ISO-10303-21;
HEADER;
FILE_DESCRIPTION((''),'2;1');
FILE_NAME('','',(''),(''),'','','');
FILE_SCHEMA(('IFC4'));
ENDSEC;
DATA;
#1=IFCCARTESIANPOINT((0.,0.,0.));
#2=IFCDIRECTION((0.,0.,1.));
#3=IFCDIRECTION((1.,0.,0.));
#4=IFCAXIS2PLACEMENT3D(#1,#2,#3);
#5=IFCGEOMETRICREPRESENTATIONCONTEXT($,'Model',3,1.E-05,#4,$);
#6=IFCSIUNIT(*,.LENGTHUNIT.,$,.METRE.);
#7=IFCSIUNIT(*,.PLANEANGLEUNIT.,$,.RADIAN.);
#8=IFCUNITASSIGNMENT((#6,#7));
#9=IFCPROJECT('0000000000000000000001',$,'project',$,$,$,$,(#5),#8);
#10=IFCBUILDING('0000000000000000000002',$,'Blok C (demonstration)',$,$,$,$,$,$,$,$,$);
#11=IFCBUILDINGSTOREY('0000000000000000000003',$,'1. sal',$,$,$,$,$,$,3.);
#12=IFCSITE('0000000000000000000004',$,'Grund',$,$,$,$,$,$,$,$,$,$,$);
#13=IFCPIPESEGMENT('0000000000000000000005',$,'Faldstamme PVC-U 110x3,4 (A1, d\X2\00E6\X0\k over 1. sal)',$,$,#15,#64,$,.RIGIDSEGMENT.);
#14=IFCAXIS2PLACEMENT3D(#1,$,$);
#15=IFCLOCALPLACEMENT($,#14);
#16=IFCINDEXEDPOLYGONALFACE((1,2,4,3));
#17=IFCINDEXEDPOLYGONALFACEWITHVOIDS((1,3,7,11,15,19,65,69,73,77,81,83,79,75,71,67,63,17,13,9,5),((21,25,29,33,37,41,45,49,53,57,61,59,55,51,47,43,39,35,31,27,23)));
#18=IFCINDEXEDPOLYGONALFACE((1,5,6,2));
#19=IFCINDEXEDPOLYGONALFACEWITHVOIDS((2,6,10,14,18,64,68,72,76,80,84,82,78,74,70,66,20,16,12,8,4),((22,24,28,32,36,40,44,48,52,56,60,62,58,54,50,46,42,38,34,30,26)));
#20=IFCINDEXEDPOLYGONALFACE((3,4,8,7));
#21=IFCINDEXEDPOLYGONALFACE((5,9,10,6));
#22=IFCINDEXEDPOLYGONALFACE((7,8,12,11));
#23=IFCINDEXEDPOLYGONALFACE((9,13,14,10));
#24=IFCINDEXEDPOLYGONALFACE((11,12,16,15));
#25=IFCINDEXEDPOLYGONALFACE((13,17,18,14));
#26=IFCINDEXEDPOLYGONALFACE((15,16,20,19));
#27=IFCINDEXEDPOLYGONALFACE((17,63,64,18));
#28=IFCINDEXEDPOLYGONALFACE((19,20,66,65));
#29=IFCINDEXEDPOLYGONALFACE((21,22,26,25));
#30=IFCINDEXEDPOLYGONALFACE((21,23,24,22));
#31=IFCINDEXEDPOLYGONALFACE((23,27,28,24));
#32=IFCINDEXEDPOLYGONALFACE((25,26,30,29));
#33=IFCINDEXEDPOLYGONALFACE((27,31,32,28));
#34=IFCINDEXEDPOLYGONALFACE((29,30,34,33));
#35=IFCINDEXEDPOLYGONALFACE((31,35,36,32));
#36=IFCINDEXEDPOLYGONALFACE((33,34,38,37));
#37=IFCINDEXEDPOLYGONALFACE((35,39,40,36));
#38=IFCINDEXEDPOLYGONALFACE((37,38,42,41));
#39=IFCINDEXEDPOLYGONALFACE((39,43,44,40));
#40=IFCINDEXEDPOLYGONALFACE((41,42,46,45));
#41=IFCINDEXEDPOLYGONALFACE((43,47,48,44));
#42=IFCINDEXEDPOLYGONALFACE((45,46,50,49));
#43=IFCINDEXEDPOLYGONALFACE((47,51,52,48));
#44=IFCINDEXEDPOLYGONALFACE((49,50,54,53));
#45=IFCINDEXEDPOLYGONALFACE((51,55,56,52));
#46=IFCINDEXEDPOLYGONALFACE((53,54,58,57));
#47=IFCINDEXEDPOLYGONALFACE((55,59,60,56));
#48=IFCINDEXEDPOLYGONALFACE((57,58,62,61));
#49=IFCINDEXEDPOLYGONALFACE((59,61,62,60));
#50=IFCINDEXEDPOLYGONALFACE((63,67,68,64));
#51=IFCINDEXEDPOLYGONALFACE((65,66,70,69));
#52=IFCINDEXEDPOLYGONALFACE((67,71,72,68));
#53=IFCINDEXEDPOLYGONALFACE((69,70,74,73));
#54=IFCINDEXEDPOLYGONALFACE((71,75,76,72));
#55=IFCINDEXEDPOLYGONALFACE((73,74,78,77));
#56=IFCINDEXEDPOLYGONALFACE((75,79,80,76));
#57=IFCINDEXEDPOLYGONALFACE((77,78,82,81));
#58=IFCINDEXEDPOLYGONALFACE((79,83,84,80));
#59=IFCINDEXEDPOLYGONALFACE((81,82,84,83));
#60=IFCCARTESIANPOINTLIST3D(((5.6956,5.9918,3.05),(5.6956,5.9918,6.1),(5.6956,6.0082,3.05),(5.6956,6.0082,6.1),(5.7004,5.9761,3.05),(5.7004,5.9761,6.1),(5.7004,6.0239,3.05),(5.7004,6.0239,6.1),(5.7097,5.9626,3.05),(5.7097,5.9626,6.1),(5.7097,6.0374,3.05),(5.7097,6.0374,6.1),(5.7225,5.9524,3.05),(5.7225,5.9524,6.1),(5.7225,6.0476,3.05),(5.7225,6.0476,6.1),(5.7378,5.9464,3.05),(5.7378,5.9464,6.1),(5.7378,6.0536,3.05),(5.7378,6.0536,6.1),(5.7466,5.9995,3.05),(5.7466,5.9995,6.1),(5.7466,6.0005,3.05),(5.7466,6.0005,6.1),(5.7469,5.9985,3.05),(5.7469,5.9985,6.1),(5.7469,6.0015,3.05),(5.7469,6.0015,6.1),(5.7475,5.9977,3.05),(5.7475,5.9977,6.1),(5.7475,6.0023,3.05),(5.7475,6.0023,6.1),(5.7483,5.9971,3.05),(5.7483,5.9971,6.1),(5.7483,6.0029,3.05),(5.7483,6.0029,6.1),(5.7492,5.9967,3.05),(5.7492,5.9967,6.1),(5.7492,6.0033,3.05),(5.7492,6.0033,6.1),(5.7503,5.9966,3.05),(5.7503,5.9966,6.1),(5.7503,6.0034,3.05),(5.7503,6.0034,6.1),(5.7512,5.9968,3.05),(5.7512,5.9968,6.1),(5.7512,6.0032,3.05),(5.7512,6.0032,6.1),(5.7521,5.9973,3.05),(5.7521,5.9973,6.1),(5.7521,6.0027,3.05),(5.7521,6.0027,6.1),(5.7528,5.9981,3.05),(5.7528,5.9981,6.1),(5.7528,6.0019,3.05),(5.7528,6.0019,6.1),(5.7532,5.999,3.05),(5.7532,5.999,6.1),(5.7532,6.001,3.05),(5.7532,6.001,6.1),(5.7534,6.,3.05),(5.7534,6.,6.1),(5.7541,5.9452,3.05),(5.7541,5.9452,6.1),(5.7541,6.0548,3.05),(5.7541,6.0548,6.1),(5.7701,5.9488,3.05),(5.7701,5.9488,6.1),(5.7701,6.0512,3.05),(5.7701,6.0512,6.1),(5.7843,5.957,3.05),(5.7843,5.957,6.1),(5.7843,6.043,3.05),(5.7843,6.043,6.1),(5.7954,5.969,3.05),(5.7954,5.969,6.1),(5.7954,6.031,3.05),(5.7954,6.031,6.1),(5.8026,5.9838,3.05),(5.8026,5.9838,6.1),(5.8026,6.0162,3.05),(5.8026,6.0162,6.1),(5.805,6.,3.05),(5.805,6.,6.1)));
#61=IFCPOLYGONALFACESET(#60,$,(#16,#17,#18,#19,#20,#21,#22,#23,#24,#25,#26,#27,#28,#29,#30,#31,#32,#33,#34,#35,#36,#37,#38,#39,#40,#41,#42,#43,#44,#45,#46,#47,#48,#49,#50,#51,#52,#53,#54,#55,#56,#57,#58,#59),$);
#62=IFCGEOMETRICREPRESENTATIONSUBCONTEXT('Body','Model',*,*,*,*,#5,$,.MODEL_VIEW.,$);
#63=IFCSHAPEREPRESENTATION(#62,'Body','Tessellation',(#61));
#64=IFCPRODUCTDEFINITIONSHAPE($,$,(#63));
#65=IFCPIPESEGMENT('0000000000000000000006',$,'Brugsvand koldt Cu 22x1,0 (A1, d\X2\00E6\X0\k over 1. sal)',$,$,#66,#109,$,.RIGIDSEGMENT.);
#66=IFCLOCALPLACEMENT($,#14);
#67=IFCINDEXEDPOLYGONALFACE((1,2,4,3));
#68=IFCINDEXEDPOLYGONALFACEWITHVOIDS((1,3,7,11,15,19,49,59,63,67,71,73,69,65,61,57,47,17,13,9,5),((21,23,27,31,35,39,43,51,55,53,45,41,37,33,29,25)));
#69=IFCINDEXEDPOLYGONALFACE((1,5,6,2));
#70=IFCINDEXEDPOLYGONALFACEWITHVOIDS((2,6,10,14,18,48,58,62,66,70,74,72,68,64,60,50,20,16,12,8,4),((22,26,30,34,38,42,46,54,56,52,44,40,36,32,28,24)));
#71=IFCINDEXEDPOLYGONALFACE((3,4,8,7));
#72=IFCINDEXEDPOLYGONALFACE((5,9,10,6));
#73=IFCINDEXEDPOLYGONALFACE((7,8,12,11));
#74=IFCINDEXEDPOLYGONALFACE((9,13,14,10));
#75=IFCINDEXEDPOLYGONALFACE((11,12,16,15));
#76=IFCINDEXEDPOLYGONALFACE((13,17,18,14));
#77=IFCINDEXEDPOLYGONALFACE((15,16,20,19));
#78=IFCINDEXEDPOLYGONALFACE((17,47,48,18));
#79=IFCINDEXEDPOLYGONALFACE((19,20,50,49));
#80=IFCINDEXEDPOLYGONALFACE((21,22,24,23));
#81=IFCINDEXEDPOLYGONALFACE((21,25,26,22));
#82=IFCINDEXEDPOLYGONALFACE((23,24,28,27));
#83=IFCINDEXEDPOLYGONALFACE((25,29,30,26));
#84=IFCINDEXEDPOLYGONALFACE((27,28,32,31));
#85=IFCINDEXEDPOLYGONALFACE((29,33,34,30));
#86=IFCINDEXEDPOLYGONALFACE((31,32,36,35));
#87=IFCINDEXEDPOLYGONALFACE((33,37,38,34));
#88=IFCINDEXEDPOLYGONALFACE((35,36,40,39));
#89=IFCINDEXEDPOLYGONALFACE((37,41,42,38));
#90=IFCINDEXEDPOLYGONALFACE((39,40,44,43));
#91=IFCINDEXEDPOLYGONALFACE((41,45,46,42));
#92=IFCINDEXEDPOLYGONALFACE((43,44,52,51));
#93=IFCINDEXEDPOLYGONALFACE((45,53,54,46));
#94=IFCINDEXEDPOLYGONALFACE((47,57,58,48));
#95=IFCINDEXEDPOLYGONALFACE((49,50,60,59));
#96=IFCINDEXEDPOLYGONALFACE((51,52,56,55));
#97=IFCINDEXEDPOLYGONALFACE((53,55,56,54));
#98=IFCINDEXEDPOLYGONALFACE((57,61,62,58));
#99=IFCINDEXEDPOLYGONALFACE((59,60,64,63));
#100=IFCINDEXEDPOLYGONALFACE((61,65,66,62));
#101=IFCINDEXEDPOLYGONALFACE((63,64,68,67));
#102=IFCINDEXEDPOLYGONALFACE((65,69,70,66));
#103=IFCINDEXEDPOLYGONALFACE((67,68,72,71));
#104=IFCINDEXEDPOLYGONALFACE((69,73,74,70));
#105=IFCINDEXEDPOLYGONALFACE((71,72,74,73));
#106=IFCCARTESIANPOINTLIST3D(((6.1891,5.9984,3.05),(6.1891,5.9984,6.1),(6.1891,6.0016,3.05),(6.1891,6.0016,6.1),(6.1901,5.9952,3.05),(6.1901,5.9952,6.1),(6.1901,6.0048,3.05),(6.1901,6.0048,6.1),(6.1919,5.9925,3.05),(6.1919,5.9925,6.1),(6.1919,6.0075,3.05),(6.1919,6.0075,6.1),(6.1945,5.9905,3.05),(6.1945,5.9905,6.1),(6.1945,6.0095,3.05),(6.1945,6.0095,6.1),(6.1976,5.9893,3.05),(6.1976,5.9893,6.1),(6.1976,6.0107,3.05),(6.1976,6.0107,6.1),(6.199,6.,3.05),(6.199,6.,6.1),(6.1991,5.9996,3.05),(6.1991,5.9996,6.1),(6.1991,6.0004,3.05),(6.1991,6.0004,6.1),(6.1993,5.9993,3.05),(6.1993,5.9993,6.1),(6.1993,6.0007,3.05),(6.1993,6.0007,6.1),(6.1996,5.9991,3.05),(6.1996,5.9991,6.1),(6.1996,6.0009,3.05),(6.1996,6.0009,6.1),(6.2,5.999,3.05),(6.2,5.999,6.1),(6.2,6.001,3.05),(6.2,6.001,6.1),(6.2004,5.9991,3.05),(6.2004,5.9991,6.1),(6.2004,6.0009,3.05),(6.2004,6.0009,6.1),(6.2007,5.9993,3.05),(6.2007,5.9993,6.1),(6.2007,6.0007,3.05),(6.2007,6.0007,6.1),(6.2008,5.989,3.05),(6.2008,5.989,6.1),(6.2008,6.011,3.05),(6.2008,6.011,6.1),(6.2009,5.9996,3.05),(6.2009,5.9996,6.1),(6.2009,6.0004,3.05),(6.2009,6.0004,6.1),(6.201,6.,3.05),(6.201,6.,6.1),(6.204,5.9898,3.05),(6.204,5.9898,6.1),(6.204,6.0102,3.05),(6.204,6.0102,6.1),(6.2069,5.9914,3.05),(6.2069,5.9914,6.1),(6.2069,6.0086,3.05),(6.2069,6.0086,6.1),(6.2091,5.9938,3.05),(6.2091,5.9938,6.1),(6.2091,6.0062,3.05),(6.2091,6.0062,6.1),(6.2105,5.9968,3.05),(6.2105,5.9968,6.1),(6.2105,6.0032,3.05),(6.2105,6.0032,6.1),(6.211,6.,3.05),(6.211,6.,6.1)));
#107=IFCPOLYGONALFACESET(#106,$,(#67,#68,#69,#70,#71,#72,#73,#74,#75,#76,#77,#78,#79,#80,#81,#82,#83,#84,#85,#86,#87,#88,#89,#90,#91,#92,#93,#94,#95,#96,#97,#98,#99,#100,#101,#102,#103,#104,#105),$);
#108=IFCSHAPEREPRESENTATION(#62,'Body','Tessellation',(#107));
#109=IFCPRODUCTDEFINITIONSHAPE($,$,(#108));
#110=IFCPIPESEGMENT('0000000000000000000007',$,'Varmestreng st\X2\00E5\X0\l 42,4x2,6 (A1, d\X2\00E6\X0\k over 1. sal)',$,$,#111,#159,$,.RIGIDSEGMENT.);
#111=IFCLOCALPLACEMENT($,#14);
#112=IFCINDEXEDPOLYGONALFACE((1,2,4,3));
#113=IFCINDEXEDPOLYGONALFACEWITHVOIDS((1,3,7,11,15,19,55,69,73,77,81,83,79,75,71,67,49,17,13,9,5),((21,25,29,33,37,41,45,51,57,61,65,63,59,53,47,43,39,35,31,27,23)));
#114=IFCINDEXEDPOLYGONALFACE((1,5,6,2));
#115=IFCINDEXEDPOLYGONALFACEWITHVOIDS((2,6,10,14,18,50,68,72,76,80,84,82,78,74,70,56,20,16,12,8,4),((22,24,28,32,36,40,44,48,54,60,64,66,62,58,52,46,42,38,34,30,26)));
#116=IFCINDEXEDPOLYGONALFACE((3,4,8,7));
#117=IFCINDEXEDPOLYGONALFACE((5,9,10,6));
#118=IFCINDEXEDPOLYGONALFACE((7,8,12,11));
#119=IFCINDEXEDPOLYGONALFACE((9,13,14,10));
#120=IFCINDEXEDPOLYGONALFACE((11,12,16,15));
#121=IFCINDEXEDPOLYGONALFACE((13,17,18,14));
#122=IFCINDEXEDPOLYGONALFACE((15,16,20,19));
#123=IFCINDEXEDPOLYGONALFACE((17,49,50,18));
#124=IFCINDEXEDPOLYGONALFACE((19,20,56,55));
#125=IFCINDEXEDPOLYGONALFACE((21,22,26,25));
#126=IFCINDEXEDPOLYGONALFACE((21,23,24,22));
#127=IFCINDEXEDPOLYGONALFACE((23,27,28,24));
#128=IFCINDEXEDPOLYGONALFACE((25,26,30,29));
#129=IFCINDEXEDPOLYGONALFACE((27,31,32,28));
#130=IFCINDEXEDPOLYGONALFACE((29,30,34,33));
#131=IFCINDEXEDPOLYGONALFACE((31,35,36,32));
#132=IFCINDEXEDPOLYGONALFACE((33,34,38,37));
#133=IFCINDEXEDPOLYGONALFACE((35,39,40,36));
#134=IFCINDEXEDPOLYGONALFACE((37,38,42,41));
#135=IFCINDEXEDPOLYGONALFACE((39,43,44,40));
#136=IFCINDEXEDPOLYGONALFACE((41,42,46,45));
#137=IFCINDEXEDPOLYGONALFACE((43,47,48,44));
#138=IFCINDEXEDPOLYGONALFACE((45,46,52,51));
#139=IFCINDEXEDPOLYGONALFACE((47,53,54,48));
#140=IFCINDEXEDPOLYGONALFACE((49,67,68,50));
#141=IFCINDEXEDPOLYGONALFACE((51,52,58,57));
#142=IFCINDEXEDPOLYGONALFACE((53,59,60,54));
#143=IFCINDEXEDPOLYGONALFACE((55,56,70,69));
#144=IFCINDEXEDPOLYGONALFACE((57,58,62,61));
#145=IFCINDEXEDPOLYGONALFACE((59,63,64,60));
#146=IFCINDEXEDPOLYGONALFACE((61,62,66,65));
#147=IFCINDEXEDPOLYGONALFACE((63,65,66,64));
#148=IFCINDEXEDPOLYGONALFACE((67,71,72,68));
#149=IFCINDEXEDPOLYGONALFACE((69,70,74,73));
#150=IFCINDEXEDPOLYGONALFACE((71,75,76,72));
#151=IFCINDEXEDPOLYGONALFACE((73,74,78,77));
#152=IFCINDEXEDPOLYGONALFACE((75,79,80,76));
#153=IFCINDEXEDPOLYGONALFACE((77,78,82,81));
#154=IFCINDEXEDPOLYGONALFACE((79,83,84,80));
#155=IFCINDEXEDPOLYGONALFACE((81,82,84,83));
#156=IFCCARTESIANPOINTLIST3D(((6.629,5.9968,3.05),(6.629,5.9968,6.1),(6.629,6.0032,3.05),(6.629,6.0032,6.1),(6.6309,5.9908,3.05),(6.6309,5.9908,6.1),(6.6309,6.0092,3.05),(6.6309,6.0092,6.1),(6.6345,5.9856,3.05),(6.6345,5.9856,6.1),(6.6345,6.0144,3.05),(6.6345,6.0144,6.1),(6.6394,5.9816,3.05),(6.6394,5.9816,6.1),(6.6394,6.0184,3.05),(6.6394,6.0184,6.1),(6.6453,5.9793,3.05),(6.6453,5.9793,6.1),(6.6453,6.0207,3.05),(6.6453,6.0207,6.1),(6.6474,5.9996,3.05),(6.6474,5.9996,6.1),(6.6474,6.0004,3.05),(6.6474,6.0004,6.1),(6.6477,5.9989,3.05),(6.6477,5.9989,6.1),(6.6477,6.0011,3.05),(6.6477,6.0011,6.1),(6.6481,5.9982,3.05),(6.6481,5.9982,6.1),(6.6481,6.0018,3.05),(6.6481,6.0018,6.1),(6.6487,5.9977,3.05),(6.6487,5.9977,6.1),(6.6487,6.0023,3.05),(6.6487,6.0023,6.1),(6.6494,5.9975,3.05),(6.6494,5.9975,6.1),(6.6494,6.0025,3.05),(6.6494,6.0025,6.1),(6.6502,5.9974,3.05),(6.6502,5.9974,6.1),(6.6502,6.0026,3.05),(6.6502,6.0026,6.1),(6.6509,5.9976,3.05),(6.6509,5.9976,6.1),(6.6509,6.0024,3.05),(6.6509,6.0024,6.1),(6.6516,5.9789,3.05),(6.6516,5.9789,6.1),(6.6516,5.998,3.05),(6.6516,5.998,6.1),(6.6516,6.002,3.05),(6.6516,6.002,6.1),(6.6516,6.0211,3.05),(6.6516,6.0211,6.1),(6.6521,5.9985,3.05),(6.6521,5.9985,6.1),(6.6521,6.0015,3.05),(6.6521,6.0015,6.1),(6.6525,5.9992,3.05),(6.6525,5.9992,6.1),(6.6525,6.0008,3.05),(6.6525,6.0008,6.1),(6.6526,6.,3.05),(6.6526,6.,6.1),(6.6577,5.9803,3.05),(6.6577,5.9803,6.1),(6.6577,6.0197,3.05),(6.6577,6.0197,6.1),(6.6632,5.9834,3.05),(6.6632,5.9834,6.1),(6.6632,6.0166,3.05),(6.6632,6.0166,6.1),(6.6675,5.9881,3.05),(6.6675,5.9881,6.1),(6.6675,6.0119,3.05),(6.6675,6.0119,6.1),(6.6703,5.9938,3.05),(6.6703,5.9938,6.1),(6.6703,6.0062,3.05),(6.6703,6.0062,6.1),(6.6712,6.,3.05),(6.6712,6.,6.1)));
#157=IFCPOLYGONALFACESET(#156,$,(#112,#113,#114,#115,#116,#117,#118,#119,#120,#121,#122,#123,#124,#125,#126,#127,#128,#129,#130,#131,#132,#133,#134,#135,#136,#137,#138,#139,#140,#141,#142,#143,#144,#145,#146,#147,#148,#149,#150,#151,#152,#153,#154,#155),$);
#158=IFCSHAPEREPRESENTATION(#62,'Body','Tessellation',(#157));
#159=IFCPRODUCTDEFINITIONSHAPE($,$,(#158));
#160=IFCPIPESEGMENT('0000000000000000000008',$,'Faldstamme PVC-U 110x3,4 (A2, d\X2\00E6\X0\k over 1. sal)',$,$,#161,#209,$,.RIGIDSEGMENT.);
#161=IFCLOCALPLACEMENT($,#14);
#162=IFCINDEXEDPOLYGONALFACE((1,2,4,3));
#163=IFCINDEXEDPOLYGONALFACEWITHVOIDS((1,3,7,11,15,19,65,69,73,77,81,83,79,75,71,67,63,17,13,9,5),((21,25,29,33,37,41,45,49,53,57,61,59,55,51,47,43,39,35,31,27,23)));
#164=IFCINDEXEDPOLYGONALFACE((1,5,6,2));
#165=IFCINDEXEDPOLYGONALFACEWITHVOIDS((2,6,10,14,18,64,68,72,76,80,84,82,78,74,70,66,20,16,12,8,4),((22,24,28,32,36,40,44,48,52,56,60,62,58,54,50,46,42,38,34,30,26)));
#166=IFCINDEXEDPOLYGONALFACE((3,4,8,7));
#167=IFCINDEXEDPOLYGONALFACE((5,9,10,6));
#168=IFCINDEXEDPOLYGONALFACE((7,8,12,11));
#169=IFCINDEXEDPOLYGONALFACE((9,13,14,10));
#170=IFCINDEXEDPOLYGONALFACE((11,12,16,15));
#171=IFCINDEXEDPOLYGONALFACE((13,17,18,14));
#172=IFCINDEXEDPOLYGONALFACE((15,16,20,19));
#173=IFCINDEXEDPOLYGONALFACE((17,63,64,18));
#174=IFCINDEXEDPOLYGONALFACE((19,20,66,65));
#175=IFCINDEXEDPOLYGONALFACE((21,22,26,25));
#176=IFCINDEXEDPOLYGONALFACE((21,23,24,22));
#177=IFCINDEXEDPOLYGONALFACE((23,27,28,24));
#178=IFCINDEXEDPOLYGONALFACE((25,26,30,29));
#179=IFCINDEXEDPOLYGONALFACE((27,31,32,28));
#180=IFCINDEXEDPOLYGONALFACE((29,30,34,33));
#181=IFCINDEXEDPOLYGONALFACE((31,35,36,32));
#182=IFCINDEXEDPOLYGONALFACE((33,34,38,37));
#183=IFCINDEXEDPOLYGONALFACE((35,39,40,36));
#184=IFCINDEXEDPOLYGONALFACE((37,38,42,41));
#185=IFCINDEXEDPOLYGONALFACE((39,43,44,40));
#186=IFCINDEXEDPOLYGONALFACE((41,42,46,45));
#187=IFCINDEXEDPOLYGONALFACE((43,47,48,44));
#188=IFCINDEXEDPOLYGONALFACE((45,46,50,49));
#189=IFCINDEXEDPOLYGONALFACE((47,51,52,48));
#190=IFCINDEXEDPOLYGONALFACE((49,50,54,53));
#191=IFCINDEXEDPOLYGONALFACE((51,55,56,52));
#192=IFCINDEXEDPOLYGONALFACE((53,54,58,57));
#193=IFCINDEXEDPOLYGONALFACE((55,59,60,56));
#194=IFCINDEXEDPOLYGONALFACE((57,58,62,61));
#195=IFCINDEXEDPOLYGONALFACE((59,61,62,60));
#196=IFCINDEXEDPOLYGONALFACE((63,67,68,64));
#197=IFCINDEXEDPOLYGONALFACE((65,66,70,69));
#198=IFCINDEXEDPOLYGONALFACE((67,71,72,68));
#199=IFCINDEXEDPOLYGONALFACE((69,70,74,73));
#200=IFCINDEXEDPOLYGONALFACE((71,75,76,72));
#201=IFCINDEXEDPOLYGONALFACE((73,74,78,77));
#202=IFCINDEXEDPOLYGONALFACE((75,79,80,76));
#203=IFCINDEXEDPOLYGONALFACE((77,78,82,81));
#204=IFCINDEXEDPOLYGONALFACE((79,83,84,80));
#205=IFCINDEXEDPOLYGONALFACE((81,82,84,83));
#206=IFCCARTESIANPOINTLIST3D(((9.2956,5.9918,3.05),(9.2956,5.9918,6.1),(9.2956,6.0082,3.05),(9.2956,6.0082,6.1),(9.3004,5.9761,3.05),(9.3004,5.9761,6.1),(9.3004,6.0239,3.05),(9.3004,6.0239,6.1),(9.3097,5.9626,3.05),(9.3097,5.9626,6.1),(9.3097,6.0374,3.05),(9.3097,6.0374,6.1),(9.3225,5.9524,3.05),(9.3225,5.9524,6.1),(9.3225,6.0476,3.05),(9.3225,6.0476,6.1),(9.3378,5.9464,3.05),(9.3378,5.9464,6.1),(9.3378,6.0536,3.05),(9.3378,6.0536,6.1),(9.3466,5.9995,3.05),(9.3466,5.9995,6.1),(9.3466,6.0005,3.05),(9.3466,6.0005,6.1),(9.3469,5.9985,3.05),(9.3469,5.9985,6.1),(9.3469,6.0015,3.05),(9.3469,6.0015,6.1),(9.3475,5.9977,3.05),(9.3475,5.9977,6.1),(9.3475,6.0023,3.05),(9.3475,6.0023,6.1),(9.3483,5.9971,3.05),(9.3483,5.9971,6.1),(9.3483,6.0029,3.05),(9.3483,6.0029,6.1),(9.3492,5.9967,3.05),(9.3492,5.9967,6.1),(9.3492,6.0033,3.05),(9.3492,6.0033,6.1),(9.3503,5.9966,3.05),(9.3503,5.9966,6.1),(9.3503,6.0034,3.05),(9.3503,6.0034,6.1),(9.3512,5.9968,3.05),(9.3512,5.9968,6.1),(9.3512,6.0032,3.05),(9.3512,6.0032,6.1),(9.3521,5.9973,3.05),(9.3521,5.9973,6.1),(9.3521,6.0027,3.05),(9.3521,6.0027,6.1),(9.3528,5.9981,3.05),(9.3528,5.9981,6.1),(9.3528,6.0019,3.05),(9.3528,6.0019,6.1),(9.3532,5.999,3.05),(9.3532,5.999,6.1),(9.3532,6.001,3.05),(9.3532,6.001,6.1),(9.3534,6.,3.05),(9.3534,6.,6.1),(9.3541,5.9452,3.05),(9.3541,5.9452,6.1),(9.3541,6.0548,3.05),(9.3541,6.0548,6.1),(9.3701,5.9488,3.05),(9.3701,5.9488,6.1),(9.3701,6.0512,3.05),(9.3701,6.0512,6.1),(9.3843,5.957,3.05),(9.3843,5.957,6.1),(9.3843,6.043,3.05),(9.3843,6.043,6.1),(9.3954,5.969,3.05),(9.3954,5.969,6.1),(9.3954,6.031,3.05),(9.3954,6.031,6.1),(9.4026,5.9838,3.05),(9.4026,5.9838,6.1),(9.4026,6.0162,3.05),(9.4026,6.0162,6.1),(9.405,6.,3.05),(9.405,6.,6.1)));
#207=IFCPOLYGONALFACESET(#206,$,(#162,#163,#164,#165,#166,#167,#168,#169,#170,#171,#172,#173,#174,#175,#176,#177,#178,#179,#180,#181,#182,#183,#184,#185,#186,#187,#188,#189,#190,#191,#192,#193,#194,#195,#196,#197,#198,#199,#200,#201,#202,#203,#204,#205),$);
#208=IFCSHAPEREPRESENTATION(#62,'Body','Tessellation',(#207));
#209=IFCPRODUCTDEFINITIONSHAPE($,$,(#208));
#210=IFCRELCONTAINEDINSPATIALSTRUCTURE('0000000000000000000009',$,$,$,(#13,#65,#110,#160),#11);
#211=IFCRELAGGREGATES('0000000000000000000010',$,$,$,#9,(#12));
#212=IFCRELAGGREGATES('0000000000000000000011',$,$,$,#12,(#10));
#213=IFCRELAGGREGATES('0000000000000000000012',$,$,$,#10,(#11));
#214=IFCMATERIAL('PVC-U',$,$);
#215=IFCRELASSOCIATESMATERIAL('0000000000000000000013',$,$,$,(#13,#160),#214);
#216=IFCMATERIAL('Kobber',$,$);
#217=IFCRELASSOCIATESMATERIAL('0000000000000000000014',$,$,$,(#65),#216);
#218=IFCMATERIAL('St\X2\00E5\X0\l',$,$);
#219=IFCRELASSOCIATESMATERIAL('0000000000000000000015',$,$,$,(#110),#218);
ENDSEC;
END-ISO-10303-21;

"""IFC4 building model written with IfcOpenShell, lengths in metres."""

from ifc_helpers import new_model, si_unit, frame, origin_with_axes, place, context, subcontext, project, spatial, hollow_circle, extrude, material, element, save


model = new_model("IFC4")

# Units and contexts
model_context = context("Model", 3, precision=1e-05, world=origin_with_axes())
body_context = subcontext(model_context, "Body", "Model", "MODEL_VIEW")
ifc_project = project(units=[si_unit("LENGTHUNIT", "METRE"), si_unit("PLANEANGLEUNIT", "RADIAN")], contexts=[model_context])

# Site, building, storey
site = spatial("IfcSite", under=ifc_project, Name="Grund")
building = spatial("IfcBuilding", under=site, Name="Blok C (demonstration)")
storey = spatial("IfcBuildingStorey", under=building, Name="1. sal", Elevation=3.0)

# Pipe segments
ifc_material_1 = material(Name="PVC-U")
pipe_segment_1_placement = place(None, origin_with_axes())
element("IfcPipeSegment", 1, at=pipe_segment_1_placement, inside=storey, material=ifc_material_1, Name="Faldstamme PVC-U 110x3,4 (A1, dæk over 1. sal)", PredefinedType="RIGIDSEGMENT", context=body_context, shape_type="SweptSolid", body=[
    extrude(hollow_circle(Radius=0.055, WallThickness=0.0516), frame((5.75, 6.0, 3.05), z_axis=(0.0, 0.0, 1.0), x_axis=(1.0, 0.0, 0.0)), (0.0, 0.0, 1.0), 3.05),
])
ifc_material_2 = material(Name="Kobber")
pipe_segment_2_placement = place(None, origin_with_axes())
element("IfcPipeSegment", 2, at=pipe_segment_2_placement, inside=storey, material=ifc_material_2, Name="Brugsvand koldt Cu 22x1,0 (A1, dæk over 1. sal)", PredefinedType="RIGIDSEGMENT", context=body_context, shape_type="SweptSolid", body=[
    extrude(hollow_circle(Radius=0.011, WallThickness=0.01), frame((6.2, 6.0, 3.05), z_axis=(0.0, 0.0, 1.0), x_axis=(1.0, 0.0, 0.0)), (0.0, 0.0, 1.0), 3.05),
])
ifc_material_3 = material(Name="Stål")
pipe_segment_3_placement = place(None, origin_with_axes())
element("IfcPipeSegment", 3, at=pipe_segment_3_placement, inside=storey, material=ifc_material_3, Name="Varmestreng stål 42,4x2,6 (A1, dæk over 1. sal)", PredefinedType="RIGIDSEGMENT", context=body_context, shape_type="SweptSolid", body=[
    extrude(hollow_circle(Radius=0.0212, WallThickness=0.0186), frame((6.65, 6.0, 3.05), z_axis=(0.0, 0.0, 1.0), x_axis=(1.0, 0.0, 0.0)), (0.0, 0.0, 1.0), 3.05),
])
pipe_segment_4_placement = place(None, origin_with_axes())
element("IfcPipeSegment", 4, at=pipe_segment_4_placement, inside=storey, material=ifc_material_1, Name="Faldstamme PVC-U 110x3,4 (A2, dæk over 1. sal)", PredefinedType="RIGIDSEGMENT", context=body_context, shape_type="SweptSolid", body=[
    extrude(hollow_circle(Radius=0.055, WallThickness=0.0516), frame((9.35, 6.0, 3.05), z_axis=(0.0, 0.0, 1.0), x_axis=(1.0, 0.0, 0.0)), (0.0, 0.0, 1.0), 3.05),
])

save(model, "model.ifc")
